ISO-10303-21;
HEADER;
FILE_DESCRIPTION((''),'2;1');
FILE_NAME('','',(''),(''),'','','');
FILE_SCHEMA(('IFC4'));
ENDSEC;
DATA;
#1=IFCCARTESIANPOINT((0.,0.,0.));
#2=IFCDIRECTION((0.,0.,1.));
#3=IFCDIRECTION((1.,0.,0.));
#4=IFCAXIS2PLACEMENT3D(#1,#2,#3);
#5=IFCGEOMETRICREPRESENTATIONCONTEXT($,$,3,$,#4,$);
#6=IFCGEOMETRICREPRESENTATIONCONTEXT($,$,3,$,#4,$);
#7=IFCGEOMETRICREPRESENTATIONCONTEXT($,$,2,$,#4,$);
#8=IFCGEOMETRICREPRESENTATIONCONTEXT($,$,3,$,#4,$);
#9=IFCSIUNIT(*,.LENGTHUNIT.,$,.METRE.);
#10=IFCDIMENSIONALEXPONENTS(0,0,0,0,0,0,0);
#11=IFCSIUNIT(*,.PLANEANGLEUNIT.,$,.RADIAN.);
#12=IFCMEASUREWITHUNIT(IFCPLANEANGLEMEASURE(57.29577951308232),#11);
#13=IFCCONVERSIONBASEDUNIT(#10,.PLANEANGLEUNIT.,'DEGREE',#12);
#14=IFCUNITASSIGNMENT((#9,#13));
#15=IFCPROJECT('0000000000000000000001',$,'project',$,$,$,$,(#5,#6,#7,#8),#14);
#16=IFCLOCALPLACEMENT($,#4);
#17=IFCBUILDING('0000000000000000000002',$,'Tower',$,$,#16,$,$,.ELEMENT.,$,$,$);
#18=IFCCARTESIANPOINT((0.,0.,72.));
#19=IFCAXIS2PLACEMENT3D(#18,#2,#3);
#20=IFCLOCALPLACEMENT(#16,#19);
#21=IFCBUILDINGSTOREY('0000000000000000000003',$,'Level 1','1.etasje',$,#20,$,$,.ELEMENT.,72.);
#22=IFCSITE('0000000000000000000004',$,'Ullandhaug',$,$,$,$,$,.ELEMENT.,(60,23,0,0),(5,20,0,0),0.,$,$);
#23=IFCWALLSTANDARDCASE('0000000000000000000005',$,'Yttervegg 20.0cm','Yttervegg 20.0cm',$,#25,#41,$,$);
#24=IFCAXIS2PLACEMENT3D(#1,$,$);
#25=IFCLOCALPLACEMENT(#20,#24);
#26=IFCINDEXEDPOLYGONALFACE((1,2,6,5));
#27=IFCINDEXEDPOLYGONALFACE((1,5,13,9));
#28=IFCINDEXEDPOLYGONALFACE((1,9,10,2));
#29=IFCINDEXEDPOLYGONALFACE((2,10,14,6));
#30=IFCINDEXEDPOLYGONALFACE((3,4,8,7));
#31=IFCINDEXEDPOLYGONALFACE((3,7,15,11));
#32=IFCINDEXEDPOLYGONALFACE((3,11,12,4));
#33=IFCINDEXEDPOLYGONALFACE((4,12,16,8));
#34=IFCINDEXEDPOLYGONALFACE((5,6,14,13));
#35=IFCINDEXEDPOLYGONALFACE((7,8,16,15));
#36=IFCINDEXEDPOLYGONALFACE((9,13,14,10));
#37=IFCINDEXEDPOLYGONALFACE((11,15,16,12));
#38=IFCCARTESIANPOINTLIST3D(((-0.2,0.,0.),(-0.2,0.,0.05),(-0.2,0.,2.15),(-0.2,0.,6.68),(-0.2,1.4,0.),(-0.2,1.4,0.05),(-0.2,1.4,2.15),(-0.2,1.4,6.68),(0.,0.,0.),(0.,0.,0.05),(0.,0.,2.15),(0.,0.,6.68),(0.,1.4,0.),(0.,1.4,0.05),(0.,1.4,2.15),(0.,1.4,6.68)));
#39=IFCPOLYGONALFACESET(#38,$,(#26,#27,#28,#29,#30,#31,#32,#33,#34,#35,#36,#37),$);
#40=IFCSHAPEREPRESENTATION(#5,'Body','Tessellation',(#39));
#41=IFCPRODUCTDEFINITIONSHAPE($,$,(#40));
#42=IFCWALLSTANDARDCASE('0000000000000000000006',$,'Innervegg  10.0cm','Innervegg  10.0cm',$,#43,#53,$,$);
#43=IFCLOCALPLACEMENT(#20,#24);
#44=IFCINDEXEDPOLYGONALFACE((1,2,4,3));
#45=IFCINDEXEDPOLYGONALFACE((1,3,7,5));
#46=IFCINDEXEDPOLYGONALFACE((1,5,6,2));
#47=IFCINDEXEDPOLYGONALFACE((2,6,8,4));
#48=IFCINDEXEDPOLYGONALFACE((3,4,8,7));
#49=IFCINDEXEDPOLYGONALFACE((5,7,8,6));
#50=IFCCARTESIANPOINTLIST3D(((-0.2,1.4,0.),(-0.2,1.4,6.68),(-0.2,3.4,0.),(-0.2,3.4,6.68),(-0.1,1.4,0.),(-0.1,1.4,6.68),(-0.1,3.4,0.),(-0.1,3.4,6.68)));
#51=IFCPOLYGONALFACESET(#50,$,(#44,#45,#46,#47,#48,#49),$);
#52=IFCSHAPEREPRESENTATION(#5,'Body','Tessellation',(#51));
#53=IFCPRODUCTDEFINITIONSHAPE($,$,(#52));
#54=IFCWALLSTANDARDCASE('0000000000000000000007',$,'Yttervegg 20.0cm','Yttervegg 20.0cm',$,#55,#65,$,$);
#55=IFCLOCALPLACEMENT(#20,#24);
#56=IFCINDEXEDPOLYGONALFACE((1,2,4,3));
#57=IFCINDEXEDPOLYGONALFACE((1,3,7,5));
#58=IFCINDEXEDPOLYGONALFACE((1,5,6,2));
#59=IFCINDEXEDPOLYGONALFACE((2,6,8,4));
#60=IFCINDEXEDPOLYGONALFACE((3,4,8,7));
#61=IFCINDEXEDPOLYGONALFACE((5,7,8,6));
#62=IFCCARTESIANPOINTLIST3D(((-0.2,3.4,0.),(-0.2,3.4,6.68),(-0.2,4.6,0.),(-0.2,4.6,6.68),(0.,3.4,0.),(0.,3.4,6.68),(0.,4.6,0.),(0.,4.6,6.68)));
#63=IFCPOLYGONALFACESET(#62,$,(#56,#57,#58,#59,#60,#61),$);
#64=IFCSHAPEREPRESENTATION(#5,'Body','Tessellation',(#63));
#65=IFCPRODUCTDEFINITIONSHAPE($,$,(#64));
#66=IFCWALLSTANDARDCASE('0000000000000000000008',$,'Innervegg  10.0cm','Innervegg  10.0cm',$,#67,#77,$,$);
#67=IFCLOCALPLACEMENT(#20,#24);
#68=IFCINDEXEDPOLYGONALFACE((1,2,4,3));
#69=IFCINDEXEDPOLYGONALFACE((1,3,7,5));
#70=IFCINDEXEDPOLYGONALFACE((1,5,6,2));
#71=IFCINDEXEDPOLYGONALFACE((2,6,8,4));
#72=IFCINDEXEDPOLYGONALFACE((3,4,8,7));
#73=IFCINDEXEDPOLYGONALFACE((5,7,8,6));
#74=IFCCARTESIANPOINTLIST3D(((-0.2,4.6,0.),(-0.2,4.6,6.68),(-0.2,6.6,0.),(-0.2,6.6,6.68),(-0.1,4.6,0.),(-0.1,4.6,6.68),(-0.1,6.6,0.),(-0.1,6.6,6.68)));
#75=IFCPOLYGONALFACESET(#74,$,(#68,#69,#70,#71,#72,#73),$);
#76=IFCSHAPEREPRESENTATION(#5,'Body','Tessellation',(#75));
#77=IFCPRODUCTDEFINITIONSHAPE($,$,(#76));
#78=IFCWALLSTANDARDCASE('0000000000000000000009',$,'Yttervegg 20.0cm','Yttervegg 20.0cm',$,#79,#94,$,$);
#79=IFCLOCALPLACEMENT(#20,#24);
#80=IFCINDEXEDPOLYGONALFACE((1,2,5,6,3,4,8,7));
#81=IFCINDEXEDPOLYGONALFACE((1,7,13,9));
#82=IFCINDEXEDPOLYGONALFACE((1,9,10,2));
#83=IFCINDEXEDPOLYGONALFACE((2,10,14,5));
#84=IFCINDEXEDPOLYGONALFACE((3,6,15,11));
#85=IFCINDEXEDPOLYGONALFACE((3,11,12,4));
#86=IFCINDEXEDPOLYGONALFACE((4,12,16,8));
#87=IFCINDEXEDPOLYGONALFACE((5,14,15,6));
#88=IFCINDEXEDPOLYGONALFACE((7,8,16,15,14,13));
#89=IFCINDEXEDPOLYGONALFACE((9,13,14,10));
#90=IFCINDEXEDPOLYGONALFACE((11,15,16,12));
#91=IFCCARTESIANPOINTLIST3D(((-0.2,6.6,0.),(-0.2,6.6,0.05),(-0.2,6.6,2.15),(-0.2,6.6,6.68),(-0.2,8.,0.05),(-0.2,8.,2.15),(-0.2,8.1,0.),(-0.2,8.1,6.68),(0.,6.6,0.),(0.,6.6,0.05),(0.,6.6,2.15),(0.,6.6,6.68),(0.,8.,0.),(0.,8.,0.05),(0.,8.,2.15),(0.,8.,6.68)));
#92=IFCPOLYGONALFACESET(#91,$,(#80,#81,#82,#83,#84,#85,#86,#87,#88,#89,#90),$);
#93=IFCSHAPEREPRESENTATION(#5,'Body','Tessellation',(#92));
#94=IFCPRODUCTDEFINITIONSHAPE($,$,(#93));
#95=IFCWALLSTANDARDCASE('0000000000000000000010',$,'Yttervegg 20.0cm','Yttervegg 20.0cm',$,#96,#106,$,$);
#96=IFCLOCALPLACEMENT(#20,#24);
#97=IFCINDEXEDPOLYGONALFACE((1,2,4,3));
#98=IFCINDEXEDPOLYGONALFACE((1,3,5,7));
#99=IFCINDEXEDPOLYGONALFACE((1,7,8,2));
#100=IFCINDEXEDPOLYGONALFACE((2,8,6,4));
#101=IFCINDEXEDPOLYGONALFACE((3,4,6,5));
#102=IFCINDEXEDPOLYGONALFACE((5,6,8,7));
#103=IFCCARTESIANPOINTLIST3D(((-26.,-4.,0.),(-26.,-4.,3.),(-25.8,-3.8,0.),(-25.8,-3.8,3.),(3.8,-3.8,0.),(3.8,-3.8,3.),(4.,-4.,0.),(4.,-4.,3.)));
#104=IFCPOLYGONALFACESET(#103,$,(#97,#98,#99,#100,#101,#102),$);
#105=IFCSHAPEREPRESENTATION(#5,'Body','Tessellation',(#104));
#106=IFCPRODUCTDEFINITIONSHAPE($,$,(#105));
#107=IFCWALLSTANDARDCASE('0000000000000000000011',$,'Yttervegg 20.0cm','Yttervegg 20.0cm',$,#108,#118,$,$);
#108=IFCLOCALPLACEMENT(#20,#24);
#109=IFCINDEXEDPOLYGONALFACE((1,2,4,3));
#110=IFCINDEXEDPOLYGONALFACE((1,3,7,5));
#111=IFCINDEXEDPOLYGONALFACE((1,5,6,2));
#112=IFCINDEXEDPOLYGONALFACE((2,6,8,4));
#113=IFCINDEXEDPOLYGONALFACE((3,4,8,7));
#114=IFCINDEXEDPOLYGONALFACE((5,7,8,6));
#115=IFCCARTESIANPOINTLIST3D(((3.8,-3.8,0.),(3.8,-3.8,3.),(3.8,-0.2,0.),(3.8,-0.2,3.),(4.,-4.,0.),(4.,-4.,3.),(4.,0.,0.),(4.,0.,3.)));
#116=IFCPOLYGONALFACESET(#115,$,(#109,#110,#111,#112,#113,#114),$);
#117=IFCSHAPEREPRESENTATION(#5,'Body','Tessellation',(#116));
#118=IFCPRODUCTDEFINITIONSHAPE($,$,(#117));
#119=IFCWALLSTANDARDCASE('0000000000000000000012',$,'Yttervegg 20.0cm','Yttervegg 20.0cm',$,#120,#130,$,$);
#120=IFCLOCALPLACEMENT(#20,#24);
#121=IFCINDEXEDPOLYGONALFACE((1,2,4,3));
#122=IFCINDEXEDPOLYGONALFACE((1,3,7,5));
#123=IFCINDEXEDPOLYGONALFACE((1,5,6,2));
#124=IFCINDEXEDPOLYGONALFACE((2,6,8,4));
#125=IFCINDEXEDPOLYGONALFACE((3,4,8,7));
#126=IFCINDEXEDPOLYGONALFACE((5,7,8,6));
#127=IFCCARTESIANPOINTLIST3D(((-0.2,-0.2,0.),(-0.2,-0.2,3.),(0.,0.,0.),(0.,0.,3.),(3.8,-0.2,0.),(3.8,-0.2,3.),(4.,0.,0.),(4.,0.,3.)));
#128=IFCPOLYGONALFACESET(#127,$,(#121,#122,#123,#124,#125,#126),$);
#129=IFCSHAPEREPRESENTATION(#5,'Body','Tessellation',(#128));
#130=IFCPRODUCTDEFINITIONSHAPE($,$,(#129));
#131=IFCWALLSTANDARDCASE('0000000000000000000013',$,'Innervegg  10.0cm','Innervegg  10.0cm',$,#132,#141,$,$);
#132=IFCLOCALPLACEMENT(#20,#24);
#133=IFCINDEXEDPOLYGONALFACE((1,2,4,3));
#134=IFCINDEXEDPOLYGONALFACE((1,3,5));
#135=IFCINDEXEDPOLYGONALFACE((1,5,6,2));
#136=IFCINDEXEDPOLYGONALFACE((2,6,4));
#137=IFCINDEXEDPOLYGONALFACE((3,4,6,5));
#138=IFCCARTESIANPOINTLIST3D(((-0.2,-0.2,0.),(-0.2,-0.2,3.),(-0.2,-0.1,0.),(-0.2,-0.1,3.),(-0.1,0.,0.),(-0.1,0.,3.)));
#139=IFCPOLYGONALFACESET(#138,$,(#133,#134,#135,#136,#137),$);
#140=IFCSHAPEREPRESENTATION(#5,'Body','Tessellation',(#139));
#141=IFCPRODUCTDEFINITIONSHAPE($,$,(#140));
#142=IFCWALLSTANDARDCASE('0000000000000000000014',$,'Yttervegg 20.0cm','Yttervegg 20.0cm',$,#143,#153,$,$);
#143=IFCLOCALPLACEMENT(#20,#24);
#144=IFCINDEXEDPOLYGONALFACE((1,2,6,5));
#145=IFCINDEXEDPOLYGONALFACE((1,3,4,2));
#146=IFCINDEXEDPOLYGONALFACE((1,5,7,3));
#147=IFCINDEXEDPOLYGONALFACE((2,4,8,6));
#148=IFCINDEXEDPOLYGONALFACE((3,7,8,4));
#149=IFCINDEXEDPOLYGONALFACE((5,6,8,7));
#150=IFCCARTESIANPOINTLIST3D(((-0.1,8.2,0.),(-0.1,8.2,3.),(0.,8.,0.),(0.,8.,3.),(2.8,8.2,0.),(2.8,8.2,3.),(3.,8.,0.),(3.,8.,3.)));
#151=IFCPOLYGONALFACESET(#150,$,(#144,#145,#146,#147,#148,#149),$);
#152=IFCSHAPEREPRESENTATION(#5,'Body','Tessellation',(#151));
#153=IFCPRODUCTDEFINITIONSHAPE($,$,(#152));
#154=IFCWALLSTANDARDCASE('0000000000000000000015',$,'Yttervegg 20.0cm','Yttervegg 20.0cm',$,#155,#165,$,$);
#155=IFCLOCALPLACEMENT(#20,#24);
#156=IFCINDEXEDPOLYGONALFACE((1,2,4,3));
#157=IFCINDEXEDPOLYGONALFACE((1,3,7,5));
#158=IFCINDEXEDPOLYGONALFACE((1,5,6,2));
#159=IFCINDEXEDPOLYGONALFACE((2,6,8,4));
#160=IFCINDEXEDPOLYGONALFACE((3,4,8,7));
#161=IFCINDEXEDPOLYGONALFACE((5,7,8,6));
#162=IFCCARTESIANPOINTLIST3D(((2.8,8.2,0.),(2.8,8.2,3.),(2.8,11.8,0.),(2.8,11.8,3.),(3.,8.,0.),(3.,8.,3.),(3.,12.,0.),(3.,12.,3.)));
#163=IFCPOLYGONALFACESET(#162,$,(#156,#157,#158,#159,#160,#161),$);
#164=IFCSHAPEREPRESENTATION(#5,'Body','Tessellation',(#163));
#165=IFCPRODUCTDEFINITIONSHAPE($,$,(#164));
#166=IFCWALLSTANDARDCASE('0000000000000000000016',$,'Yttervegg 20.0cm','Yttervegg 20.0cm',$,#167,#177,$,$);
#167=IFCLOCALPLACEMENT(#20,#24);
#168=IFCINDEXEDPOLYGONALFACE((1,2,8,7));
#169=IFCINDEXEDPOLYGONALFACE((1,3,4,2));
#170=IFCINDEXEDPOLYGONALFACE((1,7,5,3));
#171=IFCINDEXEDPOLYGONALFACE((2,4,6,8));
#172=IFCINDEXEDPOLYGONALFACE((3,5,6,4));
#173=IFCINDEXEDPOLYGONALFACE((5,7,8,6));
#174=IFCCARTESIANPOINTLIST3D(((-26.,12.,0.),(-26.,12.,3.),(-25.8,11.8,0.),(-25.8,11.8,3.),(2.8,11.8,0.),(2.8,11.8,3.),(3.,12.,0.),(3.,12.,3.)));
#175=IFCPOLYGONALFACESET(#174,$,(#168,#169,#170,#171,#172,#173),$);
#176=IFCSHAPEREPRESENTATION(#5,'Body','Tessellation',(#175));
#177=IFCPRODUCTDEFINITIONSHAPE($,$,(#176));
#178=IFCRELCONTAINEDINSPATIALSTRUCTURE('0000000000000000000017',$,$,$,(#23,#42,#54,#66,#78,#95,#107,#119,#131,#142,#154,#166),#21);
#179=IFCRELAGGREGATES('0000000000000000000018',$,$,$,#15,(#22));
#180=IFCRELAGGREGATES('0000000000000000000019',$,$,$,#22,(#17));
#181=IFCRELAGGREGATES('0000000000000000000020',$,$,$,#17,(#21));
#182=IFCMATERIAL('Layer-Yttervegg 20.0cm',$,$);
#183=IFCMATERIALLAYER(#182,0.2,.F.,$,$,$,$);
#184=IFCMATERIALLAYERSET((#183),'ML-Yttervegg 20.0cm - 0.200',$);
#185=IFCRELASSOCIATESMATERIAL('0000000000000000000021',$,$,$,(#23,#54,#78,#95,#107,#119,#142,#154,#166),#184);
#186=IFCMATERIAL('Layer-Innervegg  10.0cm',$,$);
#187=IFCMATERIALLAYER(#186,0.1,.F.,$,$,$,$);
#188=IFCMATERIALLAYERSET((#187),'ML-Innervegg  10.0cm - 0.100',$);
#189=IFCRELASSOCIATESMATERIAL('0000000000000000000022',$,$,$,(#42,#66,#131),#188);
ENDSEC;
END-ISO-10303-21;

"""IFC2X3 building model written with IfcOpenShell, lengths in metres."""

from ifc_helpers import new_model, entity, si_unit, converted_unit, frame, origin_with_axes, place, context, project, spatial, polyline, outline, extrude, material, layer, layer_set, layer_usage, element, save


model = new_model("IFC2X3")

# Units and contexts
context_of_model_1 = context(None, 3, world=origin_with_axes())
context_of_model_2 = context(None, 3, world=origin_with_axes())
context_of_model_3 = context(None, 2, world=origin_with_axes())
context_of_model_4 = context(None, 3, world=origin_with_axes())
ifc_project = project(units=[si_unit("LENGTHUNIT", "METRE"), converted_unit("PLANEANGLEUNIT", "DEGREE", entity("IfcPlaneAngleMeasure", 57.29577951308232), si_unit("PLANEANGLEUNIT", "RADIAN"), dimensions=[0, 0, 0, 0, 0, 0, 0])], contexts=[context_of_model_1, context_of_model_2, context_of_model_3, context_of_model_4])

# Site, building, storey
site = spatial("IfcSite", under=ifc_project, Name="Ullandhaug", CompositionType="ELEMENT", RefLatitude=(60, 23, 0, 0), RefLongitude=(5, 20, 0, 0), RefElevation=0.0)
building_placement = place(None, origin_with_axes())
building = spatial("IfcBuilding", under=site, at=building_placement, Name="Tower", CompositionType="ELEMENT")
storey_placement = place(building_placement, frame((0.0, 0.0, 72.0), z_axis=(0.0, 0.0, 1.0), x_axis=(1.0, 0.0, 0.0)))
storey = spatial("IfcBuildingStorey", under=building, at=storey_placement, Name="Level 1", Description="1.etasje", CompositionType="ELEMENT", Elevation=72.0)

# Shared definitions
ifc_material_1 = material(Name="Layer-Yttervegg 20.0cm")
ifc_layer_1 = layer(ifc_material_1, 0.2, ventilated=False)
ifc_layer_set_1 = layer_set([ifc_layer_1], Name="ML-Yttervegg 20.0cm - 0.200")
ifc_layer_usage_1 = layer_usage(ifc_layer_set_1, "AXIS2", "POSITIVE", 0.0)
ifc_material_2 = material(Name="Layer-Innervegg  10.0cm")
ifc_layer_2 = layer(ifc_material_2, 0.1, ventilated=False)
ifc_layer_set_2 = layer_set([ifc_layer_2], Name="ML-Innervegg  10.0cm - 0.100")
ifc_layer_usage_2 = layer_usage(ifc_layer_set_2, "AXIS2", "POSITIVE", 0.0)

# Wall, opening
wall_1_placement = place(storey_placement, frame((0.0, 0.0, 0.0), z_axis=(0.0, 0.0, 1.0), x_axis=(0.0, 1.0, 0.0)))
wall_1 = element("IfcWallStandardCase", 1, at=wall_1_placement, inside=storey, material=ifc_layer_usage_1, Name="Yttervegg 20.0cm", Description="Yttervegg 20.0cm", context=context_of_model_1, shape_type="SweptSolid", body=[
    extrude(outline(polyline([(0.0, 0.0), (1.4, 0.0), (1.4, 0.2), (0.0, 0.2), (0.0, 0.0)])), frame((0.0, 0.0, 0.0), z_axis=(0.0, 0.0, 1.0), x_axis=(1.0, 0.0, 0.0)), (0.0, 0.0, 1.0), 6.68),
])
opening_1_placement = place(wall_1_placement, frame((0.0, 0.2, 0.05), z_axis=(0.0, 0.0, 1.0), x_axis=(1.0, 0.0, 0.0)))
element("IfcOpeningElement", 2, at=opening_1_placement, cuts=wall_1, context=context_of_model_1, shape_type="SweptSolid", body=[
    extrude(outline(polyline([(0.0, 0.0), (2.1, 0.0), (2.1, 1.4), (0.0, 1.4), (0.0, 0.0)])), frame((0.0, 0.0, 0.0), z_axis=(0.0, 1.0, 0.0), x_axis=(0.0, 0.0, 1.0)), (0.0, 0.0, -1.0), 0.2),
])

# Walls
wall_2_placement = place(storey_placement, frame((-0.1, 1.4, 0.0), z_axis=(0.0, 0.0, 1.0), x_axis=(0.0, 1.0, 0.0)))
element("IfcWallStandardCase", 3, at=wall_2_placement, inside=storey, material=ifc_layer_usage_2, Name="Innervegg  10.0cm", Description="Innervegg  10.0cm", context=context_of_model_1, shape_type="SweptSolid", body=[
    extrude(outline(polyline([(0.0, 0.0), (2.0, 0.0), (2.0, 0.1), (0.0, 0.1), (0.0, 0.0)])), frame((0.0, 0.0, 0.0), z_axis=(0.0, 0.0, 1.0), x_axis=(1.0, 0.0, 0.0)), (0.0, 0.0, 1.0), 6.68),
])
wall_3_placement = place(storey_placement, frame((0.0, 3.4, 0.0), z_axis=(0.0, 0.0, 1.0), x_axis=(0.0, 1.0, 0.0)))
element("IfcWallStandardCase", 4, at=wall_3_placement, inside=storey, material=ifc_layer_usage_1, Name="Yttervegg 20.0cm", Description="Yttervegg 20.0cm", context=context_of_model_1, shape_type="SweptSolid", body=[
    extrude(outline(polyline([(0.0, 0.0), (1.2, 0.0), (1.2, 0.2), (0.0, 0.2), (0.0, 0.0)])), frame((0.0, 0.0, 0.0), z_axis=(0.0, 0.0, 1.0), x_axis=(1.0, 0.0, 0.0)), (0.0, 0.0, 1.0), 6.68),
])
wall_4_placement = place(storey_placement, frame((-0.1, 4.6, 0.0), z_axis=(0.0, 0.0, 1.0), x_axis=(0.0, 1.0, 0.0)))
element("IfcWallStandardCase", 5, at=wall_4_placement, inside=storey, material=ifc_layer_usage_2, Name="Innervegg  10.0cm", Description="Innervegg  10.0cm", context=context_of_model_1, shape_type="SweptSolid", body=[
    extrude(outline(polyline([(0.0, 0.0), (2.0, 0.0), (2.0, 0.1), (0.0, 0.1), (0.0, 0.0)])), frame((0.0, 0.0, 0.0), z_axis=(0.0, 0.0, 1.0), x_axis=(1.0, 0.0, 0.0)), (0.0, 0.0, 1.0), 6.68),
])

# Wall, opening
wall_5_placement = place(storey_placement, frame((0.0, 6.6, 0.0), z_axis=(0.0, 0.0, 1.0), x_axis=(0.0, 1.0, 0.0)))
wall_5 = element("IfcWallStandardCase", 6, at=wall_5_placement, inside=storey, material=ifc_layer_usage_1, Name="Yttervegg 20.0cm", Description="Yttervegg 20.0cm", context=context_of_model_1, shape_type="SweptSolid", body=[
    extrude(outline(polyline([(0.0, 0.0), (1.4, 0.0), (1.5, 0.2), (0.0, 0.2), (0.0, 0.0)])), frame((0.0, 0.0, 0.0), z_axis=(0.0, 0.0, 1.0), x_axis=(1.0, 0.0, 0.0)), (0.0, 0.0, 1.0), 6.68),
])
opening_2_placement = place(wall_5_placement, frame((0.0, 0.2, 0.05), z_axis=(0.0, 0.0, 1.0), x_axis=(1.0, 0.0, 0.0)))
element("IfcOpeningElement", 7, at=opening_2_placement, cuts=wall_5, context=context_of_model_1, shape_type="SweptSolid", body=[
    extrude(outline(polyline([(0.0, 0.0), (2.1, 0.0), (2.1, 1.4), (0.0, 1.4), (0.0, 0.0)])), frame((0.0, 0.0, 0.0), z_axis=(0.0, 1.0, 0.0), x_axis=(0.0, 0.0, 1.0)), (0.0, 0.0, -1.0), 0.2),
])

# Walls
wall_6_placement = place(storey_placement, frame((-26.0, -4.0, 0.0), z_axis=(0.0, 0.0, 1.0), x_axis=(1.0, 0.0, 0.0)))
element("IfcWallStandardCase", 8, at=wall_6_placement, inside=storey, material=ifc_layer_usage_1, Name="Yttervegg 20.0cm", Description="Yttervegg 20.0cm", context=context_of_model_1, shape_type="SweptSolid", body=[
    extrude(outline(polyline([(0.0, 0.0), (30.0, 0.0), (29.8, 0.2), (0.2, 0.2), (0.0, 0.0)])), origin_with_axes(), (0.0, 0.0, 1.0), 3.0),
])
wall_7_placement = place(storey_placement, frame((4.0, -4.0, 0.0), z_axis=(0.0, 0.0, 1.0), x_axis=(0.0, 1.0, 0.0)))
element("IfcWallStandardCase", 9, at=wall_7_placement, inside=storey, material=ifc_layer_usage_1, Name="Yttervegg 20.0cm", Description="Yttervegg 20.0cm", context=context_of_model_1, shape_type="SweptSolid", body=[
    extrude(outline(polyline([(0.0, 0.0), (4.0, 0.0), (3.8, 0.2), (0.2, 0.2), (0.0, 0.0)])), frame((0.0, 0.0, 0.0), z_axis=(0.0, 0.0, 1.0), x_axis=(1.0, 0.0, 0.0)), (0.0, 0.0, 1.0), 3.0),
])
wall_8_placement = place(storey_placement, frame((4.0, 0.0, 0.0), z_axis=(0.0, 0.0, 1.0), x_axis=(-1.0, 0.0, 0.0)))
element("IfcWallStandardCase", 10, at=wall_8_placement, inside=storey, material=ifc_layer_usage_1, Name="Yttervegg 20.0cm", Description="Yttervegg 20.0cm", context=context_of_model_1, shape_type="SweptSolid", body=[
    extrude(outline(polyline([(0.0, 0.0), (4.0, 0.0), (4.2, 0.2), (0.2, 0.2), (0.0, 0.0)])), frame((0.0, 0.0, 0.0), z_axis=(0.0, 0.0, 1.0), x_axis=(1.0, 0.0, 0.0)), (0.0, 0.0, 1.0), 3.0),
])
wall_9_placement = place(storey_placement, frame((-0.1, 0.0, 0.0), z_axis=(0.0, 0.0, 1.0), x_axis=(1.0, 0.0, 0.0)))
element("IfcWallStandardCase", 11, at=wall_9_placement, inside=storey, material=ifc_layer_usage_2, Name="Innervegg  10.0cm", Description="Innervegg  10.0cm", context=context_of_model_1, shape_type="SweptSolid", body=[
    extrude(outline(polyline([(0.0, 0.0), (0.0, 0.0), (0.1414, 0.0), (0.2121, 0.0707), (0.0, 0.0)])), frame((0.0, 0.0, 0.0), z_axis=(0.0, 0.0, 1.0), x_axis=(-0.707106, -0.707107, 0.0)), (0.0, 0.0, 1.0), 3.0),
])
wall_10_placement = place(storey_placement, frame((0.0, 8.0, 0.0), z_axis=(0.0, 0.0, 1.0), x_axis=(1.0, 0.0, 0.0)))
element("IfcWallStandardCase", 12, at=wall_10_placement, inside=storey, material=ifc_layer_usage_1, Name="Yttervegg 20.0cm", Description="Yttervegg 20.0cm", context=context_of_model_1, shape_type="SweptSolid", body=[
    extrude(outline(polyline([(0.0, 0.0), (3.0, 0.0), (2.8, 0.2), (-0.1, 0.2), (0.0, 0.0)])), origin_with_axes(), (0.0, 0.0, 1.0), 3.0),
])
wall_11_placement = place(storey_placement, frame((3.0, 8.0, 0.0), z_axis=(0.0, 0.0, 1.0), x_axis=(0.0, 1.0, 0.0)))
element("IfcWallStandardCase", 13, at=wall_11_placement, inside=storey, material=ifc_layer_usage_1, Name="Yttervegg 20.0cm", Description="Yttervegg 20.0cm", context=context_of_model_1, shape_type="SweptSolid", body=[
    extrude(outline(polyline([(0.0, 0.0), (4.0, 0.0), (3.8, 0.2), (0.2, 0.2), (0.0, 0.0)])), frame((0.0, 0.0, 0.0), z_axis=(0.0, 0.0, 1.0), x_axis=(1.0, 0.0, 0.0)), (0.0, 0.0, 1.0), 3.0),
])
wall_12_placement = place(storey_placement, frame((3.0, 12.0, 0.0), z_axis=(0.0, 0.0, 1.0), x_axis=(-1.0, 0.0, 0.0)))
element("IfcWallStandardCase", 14, at=wall_12_placement, inside=storey, material=ifc_layer_usage_1, Name="Yttervegg 20.0cm", Description="Yttervegg 20.0cm", context=context_of_model_1, shape_type="SweptSolid", body=[
    extrude(outline(polyline([(0.0, 0.0), (29.0, 0.0), (28.8, 0.2), (0.2, 0.2), (0.0, 0.0)])), frame((0.0, 0.0, 0.0), z_axis=(0.0, 0.0, 1.0), x_axis=(1.0, 0.0, 0.0)), (0.0, 0.0, 1.0), 3.0),
])

save(model, "model.ifc")
